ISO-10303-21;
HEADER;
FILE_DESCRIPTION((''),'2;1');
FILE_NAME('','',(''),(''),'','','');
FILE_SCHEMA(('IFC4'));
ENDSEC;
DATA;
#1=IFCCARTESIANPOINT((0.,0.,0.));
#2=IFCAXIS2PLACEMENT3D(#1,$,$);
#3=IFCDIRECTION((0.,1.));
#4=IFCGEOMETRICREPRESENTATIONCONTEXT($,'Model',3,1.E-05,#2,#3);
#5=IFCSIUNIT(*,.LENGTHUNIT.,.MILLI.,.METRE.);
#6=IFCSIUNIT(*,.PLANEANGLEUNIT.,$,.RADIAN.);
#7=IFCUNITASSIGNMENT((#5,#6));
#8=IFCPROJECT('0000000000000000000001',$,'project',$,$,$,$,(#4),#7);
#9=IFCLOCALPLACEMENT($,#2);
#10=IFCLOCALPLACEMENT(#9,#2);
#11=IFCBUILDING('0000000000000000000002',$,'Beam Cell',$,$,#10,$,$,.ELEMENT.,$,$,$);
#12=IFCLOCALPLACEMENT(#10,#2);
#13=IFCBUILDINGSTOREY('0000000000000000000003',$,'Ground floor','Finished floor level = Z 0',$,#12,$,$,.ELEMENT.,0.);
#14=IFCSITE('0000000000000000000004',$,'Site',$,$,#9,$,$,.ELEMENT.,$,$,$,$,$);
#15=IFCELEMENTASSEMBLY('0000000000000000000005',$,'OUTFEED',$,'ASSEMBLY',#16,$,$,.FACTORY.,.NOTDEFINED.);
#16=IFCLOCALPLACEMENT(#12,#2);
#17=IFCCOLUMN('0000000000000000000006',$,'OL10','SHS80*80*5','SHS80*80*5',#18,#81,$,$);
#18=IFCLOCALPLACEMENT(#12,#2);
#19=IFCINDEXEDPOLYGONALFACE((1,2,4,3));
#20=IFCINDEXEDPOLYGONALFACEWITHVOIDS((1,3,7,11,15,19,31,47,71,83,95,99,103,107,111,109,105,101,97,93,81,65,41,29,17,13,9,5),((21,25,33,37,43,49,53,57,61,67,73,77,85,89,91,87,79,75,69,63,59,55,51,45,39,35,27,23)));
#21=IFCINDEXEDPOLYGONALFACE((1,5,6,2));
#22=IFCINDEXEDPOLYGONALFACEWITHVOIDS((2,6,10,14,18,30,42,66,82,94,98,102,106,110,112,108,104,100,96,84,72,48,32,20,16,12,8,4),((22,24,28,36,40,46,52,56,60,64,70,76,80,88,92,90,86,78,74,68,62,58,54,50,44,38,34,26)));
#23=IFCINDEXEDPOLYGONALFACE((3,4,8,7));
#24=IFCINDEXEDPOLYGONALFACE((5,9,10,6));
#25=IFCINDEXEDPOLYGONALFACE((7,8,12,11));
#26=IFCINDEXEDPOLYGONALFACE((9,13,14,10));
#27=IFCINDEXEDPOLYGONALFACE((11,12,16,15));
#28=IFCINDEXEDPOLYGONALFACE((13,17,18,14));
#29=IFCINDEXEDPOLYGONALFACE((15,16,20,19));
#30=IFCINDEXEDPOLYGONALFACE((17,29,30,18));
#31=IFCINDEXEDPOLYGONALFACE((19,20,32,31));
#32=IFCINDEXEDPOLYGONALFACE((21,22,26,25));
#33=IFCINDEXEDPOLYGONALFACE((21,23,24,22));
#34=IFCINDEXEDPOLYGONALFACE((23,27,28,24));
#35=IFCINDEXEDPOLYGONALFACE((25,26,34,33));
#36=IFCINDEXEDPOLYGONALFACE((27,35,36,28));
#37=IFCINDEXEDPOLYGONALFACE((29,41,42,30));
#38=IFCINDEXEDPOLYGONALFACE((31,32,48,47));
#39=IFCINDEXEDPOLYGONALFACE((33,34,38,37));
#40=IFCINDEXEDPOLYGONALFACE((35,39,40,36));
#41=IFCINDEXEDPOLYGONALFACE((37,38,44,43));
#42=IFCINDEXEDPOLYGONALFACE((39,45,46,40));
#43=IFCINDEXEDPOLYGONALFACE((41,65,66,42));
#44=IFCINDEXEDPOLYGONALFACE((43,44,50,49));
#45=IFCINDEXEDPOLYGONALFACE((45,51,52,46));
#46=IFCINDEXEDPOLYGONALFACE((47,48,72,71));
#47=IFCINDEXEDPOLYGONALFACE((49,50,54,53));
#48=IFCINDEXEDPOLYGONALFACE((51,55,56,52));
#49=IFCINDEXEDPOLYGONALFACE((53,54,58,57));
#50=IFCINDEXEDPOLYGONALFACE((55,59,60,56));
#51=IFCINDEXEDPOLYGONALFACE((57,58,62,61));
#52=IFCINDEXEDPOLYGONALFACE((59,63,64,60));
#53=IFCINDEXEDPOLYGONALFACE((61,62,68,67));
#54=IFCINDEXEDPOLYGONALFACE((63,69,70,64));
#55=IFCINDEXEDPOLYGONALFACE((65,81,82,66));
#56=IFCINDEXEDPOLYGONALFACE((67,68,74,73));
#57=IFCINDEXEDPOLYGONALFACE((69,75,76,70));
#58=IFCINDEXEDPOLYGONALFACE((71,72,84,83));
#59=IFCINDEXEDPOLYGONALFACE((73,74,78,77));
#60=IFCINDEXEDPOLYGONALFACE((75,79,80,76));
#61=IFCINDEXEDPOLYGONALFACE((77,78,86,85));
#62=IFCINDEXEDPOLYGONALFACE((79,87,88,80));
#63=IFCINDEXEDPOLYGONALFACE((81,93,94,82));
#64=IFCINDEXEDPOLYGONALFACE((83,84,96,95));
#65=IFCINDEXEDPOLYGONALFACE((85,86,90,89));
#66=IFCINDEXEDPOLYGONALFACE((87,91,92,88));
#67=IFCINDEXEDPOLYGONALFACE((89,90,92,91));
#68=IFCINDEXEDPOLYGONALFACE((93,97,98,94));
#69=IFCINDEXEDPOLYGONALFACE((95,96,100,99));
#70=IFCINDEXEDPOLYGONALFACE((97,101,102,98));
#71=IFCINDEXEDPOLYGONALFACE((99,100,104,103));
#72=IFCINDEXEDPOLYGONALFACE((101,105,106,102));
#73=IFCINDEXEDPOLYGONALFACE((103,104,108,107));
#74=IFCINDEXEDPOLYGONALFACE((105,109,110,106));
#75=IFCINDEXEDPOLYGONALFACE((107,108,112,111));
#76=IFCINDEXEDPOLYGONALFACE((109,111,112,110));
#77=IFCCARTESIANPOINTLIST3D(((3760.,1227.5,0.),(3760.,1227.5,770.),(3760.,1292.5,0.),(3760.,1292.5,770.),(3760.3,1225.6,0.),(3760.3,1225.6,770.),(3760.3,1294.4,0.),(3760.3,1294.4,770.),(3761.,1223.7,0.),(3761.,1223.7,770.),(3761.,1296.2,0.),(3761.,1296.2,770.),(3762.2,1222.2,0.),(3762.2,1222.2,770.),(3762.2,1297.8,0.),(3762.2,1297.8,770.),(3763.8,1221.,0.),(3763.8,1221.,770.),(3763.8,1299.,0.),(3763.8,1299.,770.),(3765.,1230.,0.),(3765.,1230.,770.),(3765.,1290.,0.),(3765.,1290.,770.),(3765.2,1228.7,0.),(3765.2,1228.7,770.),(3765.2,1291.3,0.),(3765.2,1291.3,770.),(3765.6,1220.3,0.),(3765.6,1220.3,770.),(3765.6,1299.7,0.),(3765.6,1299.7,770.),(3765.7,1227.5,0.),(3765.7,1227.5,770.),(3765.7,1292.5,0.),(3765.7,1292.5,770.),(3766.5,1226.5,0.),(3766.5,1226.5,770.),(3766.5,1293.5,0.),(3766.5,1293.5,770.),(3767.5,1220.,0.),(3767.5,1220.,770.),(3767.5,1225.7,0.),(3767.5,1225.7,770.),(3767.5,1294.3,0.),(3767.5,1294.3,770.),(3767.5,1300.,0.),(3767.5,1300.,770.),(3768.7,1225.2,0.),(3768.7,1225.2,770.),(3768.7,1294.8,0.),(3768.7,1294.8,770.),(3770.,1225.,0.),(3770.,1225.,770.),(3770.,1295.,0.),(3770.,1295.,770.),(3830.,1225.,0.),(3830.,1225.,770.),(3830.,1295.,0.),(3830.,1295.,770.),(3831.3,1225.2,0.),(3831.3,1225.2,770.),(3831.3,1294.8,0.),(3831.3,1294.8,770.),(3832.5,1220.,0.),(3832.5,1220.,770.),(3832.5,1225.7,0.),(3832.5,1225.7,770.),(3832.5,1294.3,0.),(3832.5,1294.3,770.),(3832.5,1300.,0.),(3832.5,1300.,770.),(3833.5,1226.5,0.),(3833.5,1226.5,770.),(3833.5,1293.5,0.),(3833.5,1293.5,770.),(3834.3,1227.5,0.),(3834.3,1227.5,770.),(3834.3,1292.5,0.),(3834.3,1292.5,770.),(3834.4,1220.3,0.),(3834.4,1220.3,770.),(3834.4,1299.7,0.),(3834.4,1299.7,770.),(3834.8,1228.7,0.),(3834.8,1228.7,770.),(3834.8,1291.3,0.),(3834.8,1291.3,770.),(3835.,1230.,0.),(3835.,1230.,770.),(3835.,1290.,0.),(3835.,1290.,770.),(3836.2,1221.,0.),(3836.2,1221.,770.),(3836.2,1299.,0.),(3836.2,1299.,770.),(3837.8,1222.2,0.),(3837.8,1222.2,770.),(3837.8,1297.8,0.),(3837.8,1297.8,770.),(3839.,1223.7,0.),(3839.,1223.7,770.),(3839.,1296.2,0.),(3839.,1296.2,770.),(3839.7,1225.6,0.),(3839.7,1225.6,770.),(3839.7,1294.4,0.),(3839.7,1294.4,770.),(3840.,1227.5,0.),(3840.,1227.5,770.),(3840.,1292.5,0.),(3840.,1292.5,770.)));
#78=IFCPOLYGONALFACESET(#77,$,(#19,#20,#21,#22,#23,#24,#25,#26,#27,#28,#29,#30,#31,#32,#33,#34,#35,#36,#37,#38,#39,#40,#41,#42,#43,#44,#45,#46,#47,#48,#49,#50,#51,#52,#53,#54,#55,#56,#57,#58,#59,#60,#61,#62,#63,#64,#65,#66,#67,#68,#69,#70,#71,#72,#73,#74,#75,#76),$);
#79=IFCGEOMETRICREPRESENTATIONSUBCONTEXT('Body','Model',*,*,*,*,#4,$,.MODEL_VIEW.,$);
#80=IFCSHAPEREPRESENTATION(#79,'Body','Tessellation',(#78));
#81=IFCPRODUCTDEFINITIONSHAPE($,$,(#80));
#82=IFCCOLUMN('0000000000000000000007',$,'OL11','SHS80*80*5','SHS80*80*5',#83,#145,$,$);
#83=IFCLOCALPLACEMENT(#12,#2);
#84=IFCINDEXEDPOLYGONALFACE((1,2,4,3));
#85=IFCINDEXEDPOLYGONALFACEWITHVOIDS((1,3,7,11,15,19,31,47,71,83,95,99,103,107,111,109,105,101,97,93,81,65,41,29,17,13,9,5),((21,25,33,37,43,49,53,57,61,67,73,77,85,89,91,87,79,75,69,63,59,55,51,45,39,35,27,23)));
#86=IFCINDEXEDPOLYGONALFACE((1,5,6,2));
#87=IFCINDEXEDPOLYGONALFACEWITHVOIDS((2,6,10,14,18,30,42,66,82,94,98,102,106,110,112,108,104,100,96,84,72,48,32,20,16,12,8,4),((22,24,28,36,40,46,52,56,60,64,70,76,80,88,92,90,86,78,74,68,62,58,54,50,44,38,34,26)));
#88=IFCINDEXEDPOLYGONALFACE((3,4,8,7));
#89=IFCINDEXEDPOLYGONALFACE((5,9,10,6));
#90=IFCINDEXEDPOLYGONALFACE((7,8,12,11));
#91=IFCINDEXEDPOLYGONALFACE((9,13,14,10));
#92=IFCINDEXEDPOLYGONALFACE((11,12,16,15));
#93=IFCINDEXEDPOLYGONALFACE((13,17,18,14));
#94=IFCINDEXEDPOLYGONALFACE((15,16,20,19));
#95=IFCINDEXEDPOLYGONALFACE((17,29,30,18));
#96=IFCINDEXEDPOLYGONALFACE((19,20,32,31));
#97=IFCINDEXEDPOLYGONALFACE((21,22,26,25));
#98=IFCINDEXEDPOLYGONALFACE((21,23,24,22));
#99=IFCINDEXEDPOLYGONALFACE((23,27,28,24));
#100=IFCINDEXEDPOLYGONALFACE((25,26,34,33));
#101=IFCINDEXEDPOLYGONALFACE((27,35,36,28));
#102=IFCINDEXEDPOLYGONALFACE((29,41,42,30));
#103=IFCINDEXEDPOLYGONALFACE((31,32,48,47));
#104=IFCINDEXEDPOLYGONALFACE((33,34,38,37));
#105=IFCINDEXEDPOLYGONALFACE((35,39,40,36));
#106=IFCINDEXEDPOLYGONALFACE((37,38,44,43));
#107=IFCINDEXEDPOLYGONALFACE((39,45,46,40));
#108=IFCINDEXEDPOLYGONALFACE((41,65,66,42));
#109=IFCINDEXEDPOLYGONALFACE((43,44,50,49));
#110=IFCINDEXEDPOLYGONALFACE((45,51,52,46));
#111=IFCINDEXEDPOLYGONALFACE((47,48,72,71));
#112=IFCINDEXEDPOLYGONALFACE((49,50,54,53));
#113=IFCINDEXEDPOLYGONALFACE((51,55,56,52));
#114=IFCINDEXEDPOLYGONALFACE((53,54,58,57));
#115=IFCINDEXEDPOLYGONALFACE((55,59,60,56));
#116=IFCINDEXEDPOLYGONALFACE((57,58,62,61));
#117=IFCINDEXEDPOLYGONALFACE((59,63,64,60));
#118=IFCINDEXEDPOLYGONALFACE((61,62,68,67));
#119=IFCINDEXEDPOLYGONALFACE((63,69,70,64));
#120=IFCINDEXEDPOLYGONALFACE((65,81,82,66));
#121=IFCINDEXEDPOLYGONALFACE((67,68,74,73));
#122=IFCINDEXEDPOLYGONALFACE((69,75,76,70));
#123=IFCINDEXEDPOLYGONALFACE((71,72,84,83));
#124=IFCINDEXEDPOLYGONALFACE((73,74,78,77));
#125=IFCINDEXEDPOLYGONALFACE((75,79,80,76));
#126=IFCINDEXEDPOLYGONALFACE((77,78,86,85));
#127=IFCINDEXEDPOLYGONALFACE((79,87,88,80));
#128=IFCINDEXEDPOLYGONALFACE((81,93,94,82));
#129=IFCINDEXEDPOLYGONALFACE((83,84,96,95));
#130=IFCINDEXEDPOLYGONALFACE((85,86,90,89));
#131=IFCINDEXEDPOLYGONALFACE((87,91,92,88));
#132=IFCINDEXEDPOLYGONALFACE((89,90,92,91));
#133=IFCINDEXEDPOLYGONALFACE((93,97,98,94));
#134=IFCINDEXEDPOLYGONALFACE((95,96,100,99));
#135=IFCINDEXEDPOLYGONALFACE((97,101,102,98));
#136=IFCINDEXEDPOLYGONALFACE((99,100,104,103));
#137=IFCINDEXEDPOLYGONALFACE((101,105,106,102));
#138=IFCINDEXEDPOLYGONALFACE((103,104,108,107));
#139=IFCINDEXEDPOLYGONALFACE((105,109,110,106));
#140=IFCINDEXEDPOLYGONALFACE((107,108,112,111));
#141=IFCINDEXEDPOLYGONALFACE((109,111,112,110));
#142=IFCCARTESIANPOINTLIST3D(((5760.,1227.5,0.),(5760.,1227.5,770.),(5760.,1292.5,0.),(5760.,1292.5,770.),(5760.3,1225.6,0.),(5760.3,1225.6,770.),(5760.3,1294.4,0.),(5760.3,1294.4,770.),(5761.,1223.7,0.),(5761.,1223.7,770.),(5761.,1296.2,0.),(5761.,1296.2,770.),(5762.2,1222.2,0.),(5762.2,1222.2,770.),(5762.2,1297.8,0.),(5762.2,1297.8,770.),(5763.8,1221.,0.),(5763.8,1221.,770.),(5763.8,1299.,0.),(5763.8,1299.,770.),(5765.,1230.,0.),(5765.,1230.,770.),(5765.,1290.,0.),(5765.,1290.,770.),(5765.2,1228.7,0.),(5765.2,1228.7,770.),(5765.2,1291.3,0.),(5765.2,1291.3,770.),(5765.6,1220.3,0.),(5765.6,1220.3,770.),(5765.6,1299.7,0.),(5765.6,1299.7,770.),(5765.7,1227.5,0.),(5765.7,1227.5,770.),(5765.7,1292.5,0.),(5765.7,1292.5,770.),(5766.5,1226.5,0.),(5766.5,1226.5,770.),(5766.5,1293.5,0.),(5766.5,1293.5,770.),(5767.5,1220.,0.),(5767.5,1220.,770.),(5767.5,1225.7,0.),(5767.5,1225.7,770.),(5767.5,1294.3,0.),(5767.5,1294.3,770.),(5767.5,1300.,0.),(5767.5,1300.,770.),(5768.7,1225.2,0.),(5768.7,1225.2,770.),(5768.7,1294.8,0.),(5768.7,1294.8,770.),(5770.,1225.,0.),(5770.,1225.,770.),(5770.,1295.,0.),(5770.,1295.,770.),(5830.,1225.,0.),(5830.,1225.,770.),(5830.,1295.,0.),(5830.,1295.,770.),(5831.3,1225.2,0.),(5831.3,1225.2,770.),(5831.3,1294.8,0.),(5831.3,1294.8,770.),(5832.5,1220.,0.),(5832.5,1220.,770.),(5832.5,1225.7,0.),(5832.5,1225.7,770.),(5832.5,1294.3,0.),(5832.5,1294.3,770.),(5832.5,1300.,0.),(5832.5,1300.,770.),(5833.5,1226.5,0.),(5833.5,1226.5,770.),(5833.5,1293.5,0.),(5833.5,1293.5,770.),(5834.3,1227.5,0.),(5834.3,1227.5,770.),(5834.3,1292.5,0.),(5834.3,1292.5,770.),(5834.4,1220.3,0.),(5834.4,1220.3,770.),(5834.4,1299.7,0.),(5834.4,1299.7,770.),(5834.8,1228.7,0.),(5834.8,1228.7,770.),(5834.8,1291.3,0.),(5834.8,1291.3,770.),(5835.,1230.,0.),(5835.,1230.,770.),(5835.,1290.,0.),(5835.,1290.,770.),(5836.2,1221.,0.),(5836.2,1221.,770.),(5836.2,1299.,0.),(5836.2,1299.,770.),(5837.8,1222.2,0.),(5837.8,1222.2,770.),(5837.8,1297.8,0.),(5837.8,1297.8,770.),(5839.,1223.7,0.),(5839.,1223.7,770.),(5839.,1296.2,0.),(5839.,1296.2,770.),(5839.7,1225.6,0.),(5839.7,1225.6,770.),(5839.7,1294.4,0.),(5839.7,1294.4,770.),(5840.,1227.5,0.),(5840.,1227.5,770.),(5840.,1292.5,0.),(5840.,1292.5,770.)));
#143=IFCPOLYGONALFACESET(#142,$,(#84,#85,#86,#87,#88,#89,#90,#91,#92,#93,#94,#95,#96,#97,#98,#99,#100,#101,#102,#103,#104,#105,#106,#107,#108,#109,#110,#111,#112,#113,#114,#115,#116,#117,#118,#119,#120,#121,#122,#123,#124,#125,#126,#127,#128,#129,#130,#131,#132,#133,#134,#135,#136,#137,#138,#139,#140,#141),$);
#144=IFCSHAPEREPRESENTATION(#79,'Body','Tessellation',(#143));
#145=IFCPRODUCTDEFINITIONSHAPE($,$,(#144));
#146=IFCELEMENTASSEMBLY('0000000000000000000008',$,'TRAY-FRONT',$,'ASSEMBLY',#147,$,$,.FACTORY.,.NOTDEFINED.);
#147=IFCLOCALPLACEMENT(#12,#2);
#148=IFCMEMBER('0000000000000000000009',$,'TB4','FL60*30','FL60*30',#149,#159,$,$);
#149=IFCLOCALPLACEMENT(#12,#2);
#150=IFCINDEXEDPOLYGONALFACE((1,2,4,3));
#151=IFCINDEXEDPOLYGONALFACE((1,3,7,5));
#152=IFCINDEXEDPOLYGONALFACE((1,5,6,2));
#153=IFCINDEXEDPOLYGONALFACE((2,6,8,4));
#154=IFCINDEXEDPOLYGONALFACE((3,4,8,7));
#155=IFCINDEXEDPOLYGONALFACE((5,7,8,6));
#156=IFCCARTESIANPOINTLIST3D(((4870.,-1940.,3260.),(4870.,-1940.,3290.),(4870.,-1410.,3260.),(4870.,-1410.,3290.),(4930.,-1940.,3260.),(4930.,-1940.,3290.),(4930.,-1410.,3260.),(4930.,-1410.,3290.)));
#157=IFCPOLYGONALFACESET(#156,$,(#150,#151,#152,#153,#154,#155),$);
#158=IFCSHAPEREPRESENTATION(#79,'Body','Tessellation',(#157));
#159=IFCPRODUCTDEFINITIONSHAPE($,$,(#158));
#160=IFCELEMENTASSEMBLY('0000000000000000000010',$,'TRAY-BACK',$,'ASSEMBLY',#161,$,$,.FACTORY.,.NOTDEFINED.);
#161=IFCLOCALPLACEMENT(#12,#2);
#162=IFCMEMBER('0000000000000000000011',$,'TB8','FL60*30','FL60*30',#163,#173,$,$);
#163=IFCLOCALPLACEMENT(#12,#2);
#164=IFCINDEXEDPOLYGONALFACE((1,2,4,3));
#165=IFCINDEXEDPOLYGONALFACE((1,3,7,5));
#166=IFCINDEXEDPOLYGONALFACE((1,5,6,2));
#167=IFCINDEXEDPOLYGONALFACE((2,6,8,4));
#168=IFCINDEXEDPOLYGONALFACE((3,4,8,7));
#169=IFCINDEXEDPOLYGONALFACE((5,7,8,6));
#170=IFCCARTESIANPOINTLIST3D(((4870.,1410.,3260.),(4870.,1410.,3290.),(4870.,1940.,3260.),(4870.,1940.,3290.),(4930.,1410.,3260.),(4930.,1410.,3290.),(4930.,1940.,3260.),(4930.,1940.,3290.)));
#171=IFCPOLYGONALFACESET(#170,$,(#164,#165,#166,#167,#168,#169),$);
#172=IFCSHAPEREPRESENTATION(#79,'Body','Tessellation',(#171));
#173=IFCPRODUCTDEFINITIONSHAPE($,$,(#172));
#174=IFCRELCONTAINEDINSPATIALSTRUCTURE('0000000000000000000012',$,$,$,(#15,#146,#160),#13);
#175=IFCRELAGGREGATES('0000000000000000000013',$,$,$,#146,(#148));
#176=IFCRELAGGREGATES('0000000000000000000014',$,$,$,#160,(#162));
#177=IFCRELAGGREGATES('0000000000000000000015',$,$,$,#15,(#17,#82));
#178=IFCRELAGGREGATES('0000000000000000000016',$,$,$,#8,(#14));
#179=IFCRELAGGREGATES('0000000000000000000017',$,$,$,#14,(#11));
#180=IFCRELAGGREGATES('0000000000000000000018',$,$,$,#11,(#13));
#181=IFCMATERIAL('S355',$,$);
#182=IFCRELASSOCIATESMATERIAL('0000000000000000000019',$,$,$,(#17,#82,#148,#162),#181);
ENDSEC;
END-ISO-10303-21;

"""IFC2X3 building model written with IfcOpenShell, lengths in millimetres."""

from ifc_helpers import new_model, si_unit, direction, frame, origin, origin_2d, place, context, subcontext, project, spatial, rectangle, hollow_rectangle, extrude, material, element, aggregate, save


model = new_model("IFC2X3")

# Units and contexts
model_context = context("Model", 3, precision=1e-05, world=origin(), true_north=direction((0.0, 1.0)))
body_context = subcontext(model_context, "Body", "Model", "MODEL_VIEW")
ifc_project = project(units=[si_unit("LENGTHUNIT", "METRE", prefix="MILLI"), si_unit("PLANEANGLEUNIT", "RADIAN")], contexts=[model_context])

# Site, building, storey
site_placement = place(None, origin())
site = spatial("IfcSite", under=ifc_project, at=site_placement, Name="Site", CompositionType="ELEMENT")
building_placement = place(site_placement, origin())
building = spatial("IfcBuilding", under=site, at=building_placement, Name="Beam Cell", CompositionType="ELEMENT")
storey_placement = place(building_placement, origin())
storey = spatial("IfcBuildingStorey", under=building, at=storey_placement, Name="Ground floor", Description="Finished floor level = Z 0", CompositionType="ELEMENT", Elevation=0.0)

# Shared definitions
ifc_material = material(Name="S355")

# Element assembly, columns
assembly_1_placement = place(storey_placement, origin())
assembly_1 = element("IfcElementAssembly", 1, at=assembly_1_placement, inside=storey, Name="OUTFEED", ObjectType="ASSEMBLY", AssemblyPlace="FACTORY", PredefinedType="NOTDEFINED")
column_1_placement = place(storey_placement, frame((3800.0, 1260.0, 0.0), z_axis=(0.0, 0.0, 1.0), x_axis=(1.0, 0.0, 0.0)))
column_1 = element("IfcColumn", 2, at=column_1_placement, material=ifc_material, Name="OL10", Description="SHS80*80*5", ObjectType="SHS80*80*5", context=body_context, shape_type="SweptSolid", body=[
    extrude(hollow_rectangle(XDim=80.0, YDim=80.0, WallThickness=5.0, InnerFilletRadius=5.0, OuterFilletRadius=7.5, at=origin_2d()), origin(), (0.0, 0.0, 1.0), 770.0),
])
column_2_placement = place(storey_placement, frame((5800.0, 1260.0, 0.0), z_axis=(0.0, 0.0, 1.0), x_axis=(1.0, 0.0, 0.0)))
column_2 = element("IfcColumn", 3, at=column_2_placement, material=ifc_material, Name="OL11", Description="SHS80*80*5", ObjectType="SHS80*80*5", context=body_context, shape_type="SweptSolid", body=[
    extrude(hollow_rectangle(XDim=80.0, YDim=80.0, WallThickness=5.0, InnerFilletRadius=5.0, OuterFilletRadius=7.5, at=origin_2d()), origin(), (0.0, 0.0, 1.0), 770.0),
])

# Element assemblies, members
assembly_2_placement = place(storey_placement, origin())
assembly_2 = element("IfcElementAssembly", 4, at=assembly_2_placement, inside=storey, Name="TRAY-FRONT", ObjectType="ASSEMBLY", AssemblyPlace="FACTORY", PredefinedType="NOTDEFINED")
member_1_placement = place(storey_placement, frame((4900.0, -1940.0, 3275.0), z_axis=(0.0, 1.0, 0.0), x_axis=(1.0, 0.0, 0.0)))
member_1 = element("IfcMember", 5, at=member_1_placement, material=ifc_material, Name="TB4", Description="FL60*30", ObjectType="FL60*30", context=body_context, shape_type="SweptSolid", body=[
    extrude(rectangle(XDim=60.0, YDim=30.0, at=origin_2d()), origin(), (0.0, 0.0, 1.0), 530.0),
])
aggregate(assembly_2, [member_1])
assembly_3_placement = place(storey_placement, origin())
assembly_3 = element("IfcElementAssembly", 6, at=assembly_3_placement, inside=storey, Name="TRAY-BACK", ObjectType="ASSEMBLY", AssemblyPlace="FACTORY", PredefinedType="NOTDEFINED")
member_2_placement = place(storey_placement, frame((4900.0, 1410.0, 3275.0), z_axis=(0.0, 1.0, 0.0), x_axis=(1.0, 0.0, 0.0)))
member_2 = element("IfcMember", 7, at=member_2_placement, material=ifc_material, Name="TB8", Description="FL60*30", ObjectType="FL60*30", context=body_context, shape_type="SweptSolid", body=[
    extrude(rectangle(XDim=60.0, YDim=30.0, at=origin_2d()), origin(), (0.0, 0.0, 1.0), 530.0),
])
aggregate(assembly_3, [member_2])

aggregate(assembly_1, [column_1, column_2])

save(model, "model.ifc")
